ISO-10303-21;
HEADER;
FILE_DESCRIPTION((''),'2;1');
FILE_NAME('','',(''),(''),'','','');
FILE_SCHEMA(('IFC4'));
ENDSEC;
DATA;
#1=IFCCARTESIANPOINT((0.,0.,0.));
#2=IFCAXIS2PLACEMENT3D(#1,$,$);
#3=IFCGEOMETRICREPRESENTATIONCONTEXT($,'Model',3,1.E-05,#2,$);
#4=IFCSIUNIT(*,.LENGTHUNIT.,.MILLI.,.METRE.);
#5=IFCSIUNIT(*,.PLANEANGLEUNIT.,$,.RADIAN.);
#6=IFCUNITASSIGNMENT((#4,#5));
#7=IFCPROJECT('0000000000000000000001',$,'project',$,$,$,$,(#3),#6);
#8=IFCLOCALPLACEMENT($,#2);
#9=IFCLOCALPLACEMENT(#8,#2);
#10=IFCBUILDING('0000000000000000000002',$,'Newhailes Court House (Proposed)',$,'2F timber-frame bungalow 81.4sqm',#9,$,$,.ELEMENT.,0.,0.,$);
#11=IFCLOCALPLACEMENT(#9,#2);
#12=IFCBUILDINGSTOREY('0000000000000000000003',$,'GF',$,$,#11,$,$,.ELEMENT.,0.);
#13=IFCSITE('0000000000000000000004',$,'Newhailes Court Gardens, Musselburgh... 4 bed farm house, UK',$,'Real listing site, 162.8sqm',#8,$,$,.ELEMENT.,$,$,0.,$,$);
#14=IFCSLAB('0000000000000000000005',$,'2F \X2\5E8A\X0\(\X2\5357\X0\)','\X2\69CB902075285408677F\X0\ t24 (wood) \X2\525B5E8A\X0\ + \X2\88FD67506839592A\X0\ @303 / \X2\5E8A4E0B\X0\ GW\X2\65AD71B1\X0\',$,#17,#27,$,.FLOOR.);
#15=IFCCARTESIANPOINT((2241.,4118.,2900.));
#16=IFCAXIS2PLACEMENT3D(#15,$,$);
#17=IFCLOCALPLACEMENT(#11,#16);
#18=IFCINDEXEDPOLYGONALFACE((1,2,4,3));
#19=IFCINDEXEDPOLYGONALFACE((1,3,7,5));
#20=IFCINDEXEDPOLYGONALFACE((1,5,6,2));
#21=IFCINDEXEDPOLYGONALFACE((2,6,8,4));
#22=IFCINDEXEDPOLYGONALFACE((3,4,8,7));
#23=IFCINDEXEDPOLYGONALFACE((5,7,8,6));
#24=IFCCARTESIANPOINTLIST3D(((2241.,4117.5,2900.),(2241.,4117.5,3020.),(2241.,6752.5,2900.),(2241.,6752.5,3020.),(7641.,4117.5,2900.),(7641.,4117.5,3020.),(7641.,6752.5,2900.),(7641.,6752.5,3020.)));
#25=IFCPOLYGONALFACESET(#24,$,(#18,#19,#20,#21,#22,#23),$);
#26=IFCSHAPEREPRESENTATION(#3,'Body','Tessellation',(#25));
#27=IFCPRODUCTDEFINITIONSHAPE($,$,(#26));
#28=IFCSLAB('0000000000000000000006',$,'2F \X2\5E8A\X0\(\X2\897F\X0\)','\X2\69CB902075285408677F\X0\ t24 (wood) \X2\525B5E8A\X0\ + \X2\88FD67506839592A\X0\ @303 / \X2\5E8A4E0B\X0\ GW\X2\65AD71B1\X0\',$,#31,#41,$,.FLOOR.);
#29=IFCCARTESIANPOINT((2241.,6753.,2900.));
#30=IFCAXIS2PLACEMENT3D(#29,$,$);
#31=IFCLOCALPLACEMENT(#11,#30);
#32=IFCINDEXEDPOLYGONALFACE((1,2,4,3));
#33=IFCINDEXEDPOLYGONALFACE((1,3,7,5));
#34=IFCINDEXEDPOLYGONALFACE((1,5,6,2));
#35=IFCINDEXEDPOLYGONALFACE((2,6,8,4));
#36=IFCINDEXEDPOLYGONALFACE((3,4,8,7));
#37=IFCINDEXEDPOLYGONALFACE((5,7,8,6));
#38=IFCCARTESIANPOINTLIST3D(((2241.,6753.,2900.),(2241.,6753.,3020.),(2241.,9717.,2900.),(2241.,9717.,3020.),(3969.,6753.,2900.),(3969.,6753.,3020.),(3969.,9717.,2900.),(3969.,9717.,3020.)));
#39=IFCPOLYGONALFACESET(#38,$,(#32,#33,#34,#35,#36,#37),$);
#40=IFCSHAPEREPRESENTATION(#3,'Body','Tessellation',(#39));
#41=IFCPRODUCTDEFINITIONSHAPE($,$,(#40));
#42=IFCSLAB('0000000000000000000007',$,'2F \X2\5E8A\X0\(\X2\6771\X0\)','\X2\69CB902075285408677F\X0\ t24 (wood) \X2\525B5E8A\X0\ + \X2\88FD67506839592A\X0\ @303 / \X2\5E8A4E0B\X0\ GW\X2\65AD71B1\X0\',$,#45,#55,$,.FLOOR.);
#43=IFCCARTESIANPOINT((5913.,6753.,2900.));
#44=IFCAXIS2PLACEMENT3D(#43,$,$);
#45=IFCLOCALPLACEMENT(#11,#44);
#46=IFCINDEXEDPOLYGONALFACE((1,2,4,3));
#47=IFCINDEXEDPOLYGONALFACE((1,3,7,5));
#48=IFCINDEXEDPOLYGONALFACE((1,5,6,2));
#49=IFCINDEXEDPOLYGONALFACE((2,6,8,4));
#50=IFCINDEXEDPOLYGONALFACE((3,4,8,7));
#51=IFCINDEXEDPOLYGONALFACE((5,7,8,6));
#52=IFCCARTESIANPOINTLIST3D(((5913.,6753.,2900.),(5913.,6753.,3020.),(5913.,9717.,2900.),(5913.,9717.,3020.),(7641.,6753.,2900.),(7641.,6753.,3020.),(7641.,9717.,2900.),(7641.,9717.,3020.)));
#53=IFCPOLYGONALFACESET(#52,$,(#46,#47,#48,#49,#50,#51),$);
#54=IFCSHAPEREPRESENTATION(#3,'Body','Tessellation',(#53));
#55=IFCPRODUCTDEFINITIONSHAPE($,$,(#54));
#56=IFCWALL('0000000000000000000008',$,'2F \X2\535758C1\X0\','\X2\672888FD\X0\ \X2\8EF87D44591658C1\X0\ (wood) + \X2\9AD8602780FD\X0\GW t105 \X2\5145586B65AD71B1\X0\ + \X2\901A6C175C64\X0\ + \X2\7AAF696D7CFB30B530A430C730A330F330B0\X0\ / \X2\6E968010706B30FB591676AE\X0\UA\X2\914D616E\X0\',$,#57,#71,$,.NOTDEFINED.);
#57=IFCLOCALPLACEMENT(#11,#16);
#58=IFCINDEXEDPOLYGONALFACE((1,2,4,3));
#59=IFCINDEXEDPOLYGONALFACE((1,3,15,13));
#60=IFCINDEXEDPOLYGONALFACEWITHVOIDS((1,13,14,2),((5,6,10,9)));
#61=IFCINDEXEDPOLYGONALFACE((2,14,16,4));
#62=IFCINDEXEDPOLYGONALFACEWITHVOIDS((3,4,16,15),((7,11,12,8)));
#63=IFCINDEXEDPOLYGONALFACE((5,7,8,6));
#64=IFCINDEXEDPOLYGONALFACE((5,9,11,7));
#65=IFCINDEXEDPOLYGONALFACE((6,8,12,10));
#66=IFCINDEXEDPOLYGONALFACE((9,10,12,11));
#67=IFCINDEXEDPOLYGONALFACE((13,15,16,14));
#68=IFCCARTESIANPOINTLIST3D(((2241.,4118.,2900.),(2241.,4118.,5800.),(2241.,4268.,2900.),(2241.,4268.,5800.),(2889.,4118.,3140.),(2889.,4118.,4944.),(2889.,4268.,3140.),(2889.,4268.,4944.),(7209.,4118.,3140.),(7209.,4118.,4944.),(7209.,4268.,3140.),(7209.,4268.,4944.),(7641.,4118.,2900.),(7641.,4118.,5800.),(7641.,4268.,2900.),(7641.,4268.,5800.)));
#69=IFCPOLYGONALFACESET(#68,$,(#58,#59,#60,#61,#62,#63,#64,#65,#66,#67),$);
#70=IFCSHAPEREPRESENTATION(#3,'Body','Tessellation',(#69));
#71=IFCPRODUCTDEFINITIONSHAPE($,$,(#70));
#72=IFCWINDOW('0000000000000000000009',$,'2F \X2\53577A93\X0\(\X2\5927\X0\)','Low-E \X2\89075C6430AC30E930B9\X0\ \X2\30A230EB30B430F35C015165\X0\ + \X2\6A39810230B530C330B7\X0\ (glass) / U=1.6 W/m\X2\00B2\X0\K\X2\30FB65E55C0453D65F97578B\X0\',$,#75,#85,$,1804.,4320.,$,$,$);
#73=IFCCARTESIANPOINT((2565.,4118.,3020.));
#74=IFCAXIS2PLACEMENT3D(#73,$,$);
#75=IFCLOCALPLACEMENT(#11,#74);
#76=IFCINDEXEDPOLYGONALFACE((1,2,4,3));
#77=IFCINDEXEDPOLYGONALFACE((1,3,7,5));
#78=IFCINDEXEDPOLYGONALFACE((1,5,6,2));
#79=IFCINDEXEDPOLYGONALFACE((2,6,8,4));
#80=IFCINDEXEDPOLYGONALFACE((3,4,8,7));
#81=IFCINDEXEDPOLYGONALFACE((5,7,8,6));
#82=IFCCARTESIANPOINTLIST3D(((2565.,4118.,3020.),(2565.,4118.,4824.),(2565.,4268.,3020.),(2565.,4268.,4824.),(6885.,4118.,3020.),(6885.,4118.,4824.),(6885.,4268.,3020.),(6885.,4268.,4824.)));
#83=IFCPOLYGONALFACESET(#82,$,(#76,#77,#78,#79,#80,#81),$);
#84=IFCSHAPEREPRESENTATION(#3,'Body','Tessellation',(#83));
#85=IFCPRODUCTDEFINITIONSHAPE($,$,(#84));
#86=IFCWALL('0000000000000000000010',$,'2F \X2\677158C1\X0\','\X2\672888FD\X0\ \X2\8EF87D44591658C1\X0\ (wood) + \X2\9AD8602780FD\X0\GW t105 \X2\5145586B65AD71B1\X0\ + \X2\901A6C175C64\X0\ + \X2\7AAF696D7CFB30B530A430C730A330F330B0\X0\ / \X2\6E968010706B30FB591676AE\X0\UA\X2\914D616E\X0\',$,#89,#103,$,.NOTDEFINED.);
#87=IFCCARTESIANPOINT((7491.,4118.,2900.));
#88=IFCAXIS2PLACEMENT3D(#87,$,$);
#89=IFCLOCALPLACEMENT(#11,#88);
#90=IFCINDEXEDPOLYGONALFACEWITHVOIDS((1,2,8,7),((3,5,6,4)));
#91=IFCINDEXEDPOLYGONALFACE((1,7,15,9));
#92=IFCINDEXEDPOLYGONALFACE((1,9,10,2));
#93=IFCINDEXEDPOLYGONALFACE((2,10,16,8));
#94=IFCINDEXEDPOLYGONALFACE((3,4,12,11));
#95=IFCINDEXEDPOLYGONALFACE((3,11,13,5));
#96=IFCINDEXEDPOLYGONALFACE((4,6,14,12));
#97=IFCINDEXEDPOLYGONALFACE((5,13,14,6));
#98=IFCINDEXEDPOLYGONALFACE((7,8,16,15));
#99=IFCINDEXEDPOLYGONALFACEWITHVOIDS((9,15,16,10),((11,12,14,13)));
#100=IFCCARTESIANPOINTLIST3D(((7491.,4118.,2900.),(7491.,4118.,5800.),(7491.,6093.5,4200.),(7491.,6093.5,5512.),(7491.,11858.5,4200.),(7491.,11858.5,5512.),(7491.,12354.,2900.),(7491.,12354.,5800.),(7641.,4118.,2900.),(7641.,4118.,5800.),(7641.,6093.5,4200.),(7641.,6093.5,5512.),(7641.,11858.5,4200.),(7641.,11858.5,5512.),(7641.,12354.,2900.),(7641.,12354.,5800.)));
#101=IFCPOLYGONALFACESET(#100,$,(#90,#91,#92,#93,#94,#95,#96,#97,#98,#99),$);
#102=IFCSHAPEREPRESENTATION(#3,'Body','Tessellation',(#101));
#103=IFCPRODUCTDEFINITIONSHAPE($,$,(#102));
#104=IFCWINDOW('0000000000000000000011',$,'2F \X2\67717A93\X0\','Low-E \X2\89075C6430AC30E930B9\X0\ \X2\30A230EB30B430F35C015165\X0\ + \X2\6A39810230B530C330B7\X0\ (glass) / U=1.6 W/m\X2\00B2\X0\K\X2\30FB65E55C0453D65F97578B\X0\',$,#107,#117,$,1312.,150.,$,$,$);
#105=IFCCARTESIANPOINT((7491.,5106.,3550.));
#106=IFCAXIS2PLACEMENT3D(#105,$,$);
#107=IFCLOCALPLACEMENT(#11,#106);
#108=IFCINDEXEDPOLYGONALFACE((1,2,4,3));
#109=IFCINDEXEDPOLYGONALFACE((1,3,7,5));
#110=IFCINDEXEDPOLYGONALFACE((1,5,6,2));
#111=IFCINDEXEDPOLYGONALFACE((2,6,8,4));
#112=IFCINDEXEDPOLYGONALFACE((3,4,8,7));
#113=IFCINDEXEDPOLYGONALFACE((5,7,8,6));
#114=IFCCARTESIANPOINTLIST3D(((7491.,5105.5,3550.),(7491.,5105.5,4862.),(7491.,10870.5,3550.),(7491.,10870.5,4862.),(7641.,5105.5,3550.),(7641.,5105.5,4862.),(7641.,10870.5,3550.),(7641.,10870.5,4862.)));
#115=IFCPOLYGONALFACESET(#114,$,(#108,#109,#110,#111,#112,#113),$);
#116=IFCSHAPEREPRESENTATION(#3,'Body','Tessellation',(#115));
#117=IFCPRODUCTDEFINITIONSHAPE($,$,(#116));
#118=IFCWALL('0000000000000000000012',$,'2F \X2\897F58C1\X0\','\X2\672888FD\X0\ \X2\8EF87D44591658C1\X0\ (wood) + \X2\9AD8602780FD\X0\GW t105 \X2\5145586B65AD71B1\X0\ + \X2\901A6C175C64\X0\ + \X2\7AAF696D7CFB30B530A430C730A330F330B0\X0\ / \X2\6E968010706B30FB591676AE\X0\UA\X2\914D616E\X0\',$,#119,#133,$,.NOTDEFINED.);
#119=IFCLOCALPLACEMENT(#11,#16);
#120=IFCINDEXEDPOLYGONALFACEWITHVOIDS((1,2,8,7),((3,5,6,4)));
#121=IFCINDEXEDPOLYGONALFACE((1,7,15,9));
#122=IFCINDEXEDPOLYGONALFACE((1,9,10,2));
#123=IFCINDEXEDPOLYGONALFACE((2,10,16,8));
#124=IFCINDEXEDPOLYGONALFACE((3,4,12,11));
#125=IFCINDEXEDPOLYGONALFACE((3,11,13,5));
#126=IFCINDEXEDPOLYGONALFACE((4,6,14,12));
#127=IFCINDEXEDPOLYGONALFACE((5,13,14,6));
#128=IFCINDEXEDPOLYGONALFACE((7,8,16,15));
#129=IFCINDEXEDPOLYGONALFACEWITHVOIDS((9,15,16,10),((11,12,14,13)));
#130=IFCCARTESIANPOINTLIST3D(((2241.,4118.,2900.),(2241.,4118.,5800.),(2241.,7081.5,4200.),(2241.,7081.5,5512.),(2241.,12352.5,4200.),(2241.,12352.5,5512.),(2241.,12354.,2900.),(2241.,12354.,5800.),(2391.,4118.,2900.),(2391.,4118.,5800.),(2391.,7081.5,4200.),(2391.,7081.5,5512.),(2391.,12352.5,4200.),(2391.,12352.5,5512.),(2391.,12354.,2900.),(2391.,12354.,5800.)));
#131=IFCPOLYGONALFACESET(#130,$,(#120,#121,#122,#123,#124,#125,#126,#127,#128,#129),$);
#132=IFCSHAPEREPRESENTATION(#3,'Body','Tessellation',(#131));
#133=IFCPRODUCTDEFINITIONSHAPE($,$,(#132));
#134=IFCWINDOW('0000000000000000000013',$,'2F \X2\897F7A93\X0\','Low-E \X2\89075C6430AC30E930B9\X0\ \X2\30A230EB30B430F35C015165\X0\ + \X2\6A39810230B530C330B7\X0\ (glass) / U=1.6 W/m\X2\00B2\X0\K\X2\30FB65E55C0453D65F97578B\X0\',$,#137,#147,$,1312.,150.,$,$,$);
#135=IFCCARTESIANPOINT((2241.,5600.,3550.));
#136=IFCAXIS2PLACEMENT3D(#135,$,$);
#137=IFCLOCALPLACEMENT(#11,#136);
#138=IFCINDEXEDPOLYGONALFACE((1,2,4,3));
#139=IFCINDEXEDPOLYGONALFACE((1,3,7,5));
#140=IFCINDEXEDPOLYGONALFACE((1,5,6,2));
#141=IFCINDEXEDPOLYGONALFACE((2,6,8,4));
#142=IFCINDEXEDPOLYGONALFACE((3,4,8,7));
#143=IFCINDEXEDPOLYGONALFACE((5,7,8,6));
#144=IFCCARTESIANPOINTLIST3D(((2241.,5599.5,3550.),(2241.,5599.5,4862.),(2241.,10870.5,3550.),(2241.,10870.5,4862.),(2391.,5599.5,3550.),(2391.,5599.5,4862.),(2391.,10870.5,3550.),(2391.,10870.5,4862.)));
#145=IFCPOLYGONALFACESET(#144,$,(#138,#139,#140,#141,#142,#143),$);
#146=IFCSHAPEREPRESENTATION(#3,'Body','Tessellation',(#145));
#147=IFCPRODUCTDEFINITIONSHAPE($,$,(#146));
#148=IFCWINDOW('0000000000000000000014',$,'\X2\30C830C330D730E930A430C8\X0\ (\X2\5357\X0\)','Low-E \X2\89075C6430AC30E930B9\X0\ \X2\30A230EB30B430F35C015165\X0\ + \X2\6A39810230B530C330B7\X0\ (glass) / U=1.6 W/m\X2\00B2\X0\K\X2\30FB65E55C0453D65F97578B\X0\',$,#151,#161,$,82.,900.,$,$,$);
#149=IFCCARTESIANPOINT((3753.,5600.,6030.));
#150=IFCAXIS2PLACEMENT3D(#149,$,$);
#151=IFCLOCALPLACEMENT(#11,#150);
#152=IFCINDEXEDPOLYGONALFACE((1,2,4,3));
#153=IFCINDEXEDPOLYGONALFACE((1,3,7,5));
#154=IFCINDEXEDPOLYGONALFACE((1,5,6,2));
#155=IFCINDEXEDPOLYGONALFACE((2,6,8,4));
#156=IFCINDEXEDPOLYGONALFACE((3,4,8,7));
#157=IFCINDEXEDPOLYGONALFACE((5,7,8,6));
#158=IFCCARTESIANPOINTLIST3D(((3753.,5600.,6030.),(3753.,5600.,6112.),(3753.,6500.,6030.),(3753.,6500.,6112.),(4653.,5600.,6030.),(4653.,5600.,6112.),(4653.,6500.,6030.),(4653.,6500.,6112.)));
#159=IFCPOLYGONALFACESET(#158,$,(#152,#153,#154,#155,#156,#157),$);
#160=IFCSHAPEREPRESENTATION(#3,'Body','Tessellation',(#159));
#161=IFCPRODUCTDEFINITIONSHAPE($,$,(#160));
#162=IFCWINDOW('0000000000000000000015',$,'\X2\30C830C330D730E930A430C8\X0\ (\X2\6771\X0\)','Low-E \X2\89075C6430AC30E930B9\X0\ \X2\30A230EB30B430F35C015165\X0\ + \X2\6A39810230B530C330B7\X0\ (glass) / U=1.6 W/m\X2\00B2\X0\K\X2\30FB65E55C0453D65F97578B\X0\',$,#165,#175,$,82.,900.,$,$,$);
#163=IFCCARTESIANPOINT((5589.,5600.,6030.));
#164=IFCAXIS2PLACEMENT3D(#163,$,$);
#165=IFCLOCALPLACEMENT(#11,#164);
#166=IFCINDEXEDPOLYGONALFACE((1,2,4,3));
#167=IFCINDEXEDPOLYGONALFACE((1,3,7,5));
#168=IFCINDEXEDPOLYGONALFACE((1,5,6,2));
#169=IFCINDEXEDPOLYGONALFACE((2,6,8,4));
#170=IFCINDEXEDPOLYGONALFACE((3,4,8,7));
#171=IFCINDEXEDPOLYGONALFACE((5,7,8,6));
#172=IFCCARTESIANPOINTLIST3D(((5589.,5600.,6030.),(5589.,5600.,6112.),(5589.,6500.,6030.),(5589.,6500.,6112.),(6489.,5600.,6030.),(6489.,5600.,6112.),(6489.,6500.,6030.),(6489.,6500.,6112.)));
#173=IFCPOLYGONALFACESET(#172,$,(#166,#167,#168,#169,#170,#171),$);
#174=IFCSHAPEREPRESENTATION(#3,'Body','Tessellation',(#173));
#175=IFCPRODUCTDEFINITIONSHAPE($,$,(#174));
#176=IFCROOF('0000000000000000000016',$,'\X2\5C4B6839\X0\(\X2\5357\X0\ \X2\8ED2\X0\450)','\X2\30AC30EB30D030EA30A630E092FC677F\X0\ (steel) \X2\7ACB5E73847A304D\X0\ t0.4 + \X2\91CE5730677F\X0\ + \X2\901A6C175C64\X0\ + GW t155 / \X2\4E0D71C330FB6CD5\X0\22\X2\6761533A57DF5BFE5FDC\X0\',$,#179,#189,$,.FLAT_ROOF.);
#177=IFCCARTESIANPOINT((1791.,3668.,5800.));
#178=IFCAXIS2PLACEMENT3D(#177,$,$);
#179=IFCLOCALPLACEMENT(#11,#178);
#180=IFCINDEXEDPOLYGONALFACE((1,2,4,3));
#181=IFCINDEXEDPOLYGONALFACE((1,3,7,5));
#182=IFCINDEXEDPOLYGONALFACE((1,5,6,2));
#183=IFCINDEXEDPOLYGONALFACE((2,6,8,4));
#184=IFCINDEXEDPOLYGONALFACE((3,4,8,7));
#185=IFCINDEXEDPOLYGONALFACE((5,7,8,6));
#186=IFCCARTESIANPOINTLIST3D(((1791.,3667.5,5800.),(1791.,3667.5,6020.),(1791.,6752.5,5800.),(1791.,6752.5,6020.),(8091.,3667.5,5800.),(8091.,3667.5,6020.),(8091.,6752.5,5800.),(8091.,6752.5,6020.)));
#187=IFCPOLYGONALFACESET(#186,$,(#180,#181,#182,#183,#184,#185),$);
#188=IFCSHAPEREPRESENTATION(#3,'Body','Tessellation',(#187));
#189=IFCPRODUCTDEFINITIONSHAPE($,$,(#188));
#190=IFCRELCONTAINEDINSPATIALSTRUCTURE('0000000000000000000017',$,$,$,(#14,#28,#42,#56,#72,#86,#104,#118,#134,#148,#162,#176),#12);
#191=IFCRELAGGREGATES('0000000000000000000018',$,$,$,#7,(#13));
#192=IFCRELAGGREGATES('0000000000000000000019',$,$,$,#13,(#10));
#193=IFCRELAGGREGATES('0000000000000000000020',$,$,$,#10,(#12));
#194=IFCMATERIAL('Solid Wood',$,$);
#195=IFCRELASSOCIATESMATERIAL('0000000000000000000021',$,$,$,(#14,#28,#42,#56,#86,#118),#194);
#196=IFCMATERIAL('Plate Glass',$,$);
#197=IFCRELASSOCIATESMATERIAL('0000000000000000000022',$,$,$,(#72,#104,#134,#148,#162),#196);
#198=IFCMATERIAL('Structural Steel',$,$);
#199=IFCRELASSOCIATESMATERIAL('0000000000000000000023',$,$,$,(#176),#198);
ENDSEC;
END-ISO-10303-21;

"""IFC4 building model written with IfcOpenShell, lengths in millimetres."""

from ifc_helpers import new_model, si_unit, frame, frame_2d, origin, place, context, project, spatial, rectangle, extrude, material, element, fill, save


model = new_model("IFC4")

# Units and contexts
model_context = context("Model", 3, precision=1e-05, world=origin())
ifc_project = project(units=[si_unit("LENGTHUNIT", "METRE", prefix="MILLI"), si_unit("PLANEANGLEUNIT", "RADIAN")], contexts=[model_context])

# Site, building, storey
site_placement = place(None, origin())
site = spatial("IfcSite", under=ifc_project, at=site_placement, Name="Newhailes Court Gardens, Musselburgh... 4 bed farm house, UK", ObjectType="Real listing site, 162.8sqm", CompositionType="ELEMENT", RefElevation=0.0)
building_placement = place(site_placement, origin())
building = spatial("IfcBuilding", under=site, at=building_placement, Name="Newhailes Court House (Proposed)", ObjectType="2F timber-frame bungalow 81.4sqm", CompositionType="ELEMENT", ElevationOfRefHeight=0.0, ElevationOfTerrain=0.0)
storey_placement = place(building_placement, origin())
storey = spatial("IfcBuildingStorey", under=building, at=storey_placement, Name="GF", CompositionType="ELEMENT", Elevation=0.0)

# Slabs
ifc_material_1 = material(Name="Solid Wood")
slab_1_placement = place(storey_placement, frame((2241.0, 4118.0, 2900.0)))
element("IfcSlab", 1, at=slab_1_placement, inside=storey, material=ifc_material_1, Name="2F 床(南)", Description="構造用合板 t24 (wood) 剛床 + 製材根太 @303 / 床下 GW断熱", PredefinedType="FLOOR", context=model_context, shape_type="SweptSolid", body=[
    extrude(rectangle(XDim=5400.0, YDim=2635.0, at=frame_2d((2700.0, 1317.0))), frame((2241.0, 4118.0, 2900.0)), (0.0, 0.0, 1.0), 120.0),
])
slab_2_placement = place(storey_placement, frame((2241.0, 6753.0, 2900.0)))
element("IfcSlab", 2, at=slab_2_placement, inside=storey, material=ifc_material_1, Name="2F 床(西)", Description="構造用合板 t24 (wood) 剛床 + 製材根太 @303 / 床下 GW断熱", PredefinedType="FLOOR", context=model_context, shape_type="SweptSolid", body=[
    extrude(rectangle(XDim=1728.0, YDim=2964.0, at=frame_2d((864.0, 1482.0))), frame((2241.0, 6753.0, 2900.0)), (0.0, 0.0, 1.0), 120.0),
])
slab_3_placement = place(storey_placement, frame((5913.0, 6753.0, 2900.0)))
element("IfcSlab", 3, at=slab_3_placement, inside=storey, material=ifc_material_1, Name="2F 床(東)", Description="構造用合板 t24 (wood) 剛床 + 製材根太 @303 / 床下 GW断熱", PredefinedType="FLOOR", context=model_context, shape_type="SweptSolid", body=[
    extrude(rectangle(XDim=1728.0, YDim=2964.0, at=frame_2d((864.0, 1482.0))), frame((5913.0, 6753.0, 2900.0)), (0.0, 0.0, 1.0), 120.0),
])

# Walls, openings, windows
wall_1_placement = place(storey_placement, frame((2241.0, 4118.0, 2900.0)))
wall_1 = element("IfcWall", 4, at=wall_1_placement, inside=storey, material=ifc_material_1, Name="2F 南壁", Description="木製 軸組外壁 (wood) + 高性能GW t105 充填断熱 + 通気層 + 窯業系サイディング / 準耐火・外皮UA配慮", PredefinedType="NOTDEFINED", context=model_context, shape_type="SweptSolid", body=[
    extrude(rectangle(XDim=5400.0, YDim=150.0, at=frame_2d((2700.0, 75.0))), frame((2241.0, 4118.0, 2900.0)), (0.0, 0.0, 1.0), 2900.0),
])
opening_1_placement = place(storey_placement, frame((2565.0, 4118.0, 3020.0)))
opening_1 = element("IfcOpeningElement", 5, at=opening_1_placement, cuts=wall_1, PredefinedType="NOTDEFINED", context=model_context, shape_type="SweptSolid", body=[
    extrude(rectangle(XDim=4320.0, YDim=150.0, at=frame_2d((2160.0, 75.0))), frame((2565.0, 4118.0, 3020.0)), (0.0, 0.0, 1.0), 1804.0),
])
ifc_material_2 = material(Name="Plate Glass")
window_1_placement = place(storey_placement, frame((2565.0, 4118.0, 3020.0)))
window_1 = element("IfcWindow", 6, at=window_1_placement, inside=storey, material=ifc_material_2, Name="2F 南窓(大)", Description="Low-E 複層ガラス アルゴン封入 + 樹脂サッシ (glass) / U=1.6 W/m²K・日射取得型", OverallHeight=1804.0, OverallWidth=4320.0, context=model_context, shape_type="SweptSolid", body=[
    extrude(rectangle(XDim=4320.0, YDim=150.0, at=frame_2d((2160.0, 75.0))), frame((2565.0, 4118.0, 3020.0)), (0.0, 0.0, 1.0), 1804.0),
])
fill(opening_1, window_1)
wall_2_placement = place(storey_placement, frame((7491.0, 4118.0, 2900.0)))
wall_2 = element("IfcWall", 7, at=wall_2_placement, inside=storey, material=ifc_material_1, Name="2F 東壁", Description="木製 軸組外壁 (wood) + 高性能GW t105 充填断熱 + 通気層 + 窯業系サイディング / 準耐火・外皮UA配慮", PredefinedType="NOTDEFINED", context=model_context, shape_type="SweptSolid", body=[
    extrude(rectangle(XDim=150.0, YDim=8236.0, at=frame_2d((75.0, 4118.0))), frame((7491.0, 4118.0, 2900.0)), (0.0, 0.0, 1.0), 2900.0),
])
opening_2_placement = place(storey_placement, frame((7491.0, 5106.0, 3550.0)))
opening_2 = element("IfcOpeningElement", 8, at=opening_2_placement, cuts=wall_2, PredefinedType="NOTDEFINED", context=model_context, shape_type="SweptSolid", body=[
    extrude(rectangle(XDim=150.0, YDim=5765.0, at=frame_2d((75.0, 2882.0))), frame((7491.0, 5106.0, 3550.0)), (0.0, 0.0, 1.0), 1312.0),
])
window_2_placement = place(storey_placement, frame((7491.0, 5106.0, 3550.0)))
window_2 = element("IfcWindow", 9, at=window_2_placement, inside=storey, material=ifc_material_2, Name="2F 東窓", Description="Low-E 複層ガラス アルゴン封入 + 樹脂サッシ (glass) / U=1.6 W/m²K・日射取得型", OverallHeight=1312.0, OverallWidth=150.0, context=model_context, shape_type="SweptSolid", body=[
    extrude(rectangle(XDim=150.0, YDim=5765.0, at=frame_2d((75.0, 2882.0))), frame((7491.0, 5106.0, 3550.0)), (0.0, 0.0, 1.0), 1312.0),
])
fill(opening_2, window_2)
wall_3_placement = place(storey_placement, frame((2241.0, 4118.0, 2900.0)))
wall_3 = element("IfcWall", 10, at=wall_3_placement, inside=storey, material=ifc_material_1, Name="2F 西壁", Description="木製 軸組外壁 (wood) + 高性能GW t105 充填断熱 + 通気層 + 窯業系サイディング / 準耐火・外皮UA配慮", PredefinedType="NOTDEFINED", context=model_context, shape_type="SweptSolid", body=[
    extrude(rectangle(XDim=150.0, YDim=8236.0, at=frame_2d((75.0, 4118.0))), frame((2241.0, 4118.0, 2900.0)), (0.0, 0.0, 1.0), 2900.0),
])
opening_3_placement = place(storey_placement, frame((2241.0, 5600.0, 3550.0)))
opening_3 = element("IfcOpeningElement", 11, at=opening_3_placement, cuts=wall_3, PredefinedType="NOTDEFINED", context=model_context, shape_type="SweptSolid", body=[
    extrude(rectangle(XDim=150.0, YDim=5271.0, at=frame_2d((75.0, 2635.0))), frame((2241.0, 5600.0, 3550.0)), (0.0, 0.0, 1.0), 1312.0),
])
window_3_placement = place(storey_placement, frame((2241.0, 5600.0, 3550.0)))
window_3 = element("IfcWindow", 12, at=window_3_placement, inside=storey, material=ifc_material_2, Name="2F 西窓", Description="Low-E 複層ガラス アルゴン封入 + 樹脂サッシ (glass) / U=1.6 W/m²K・日射取得型", OverallHeight=1312.0, OverallWidth=150.0, context=model_context, shape_type="SweptSolid", body=[
    extrude(rectangle(XDim=150.0, YDim=5271.0, at=frame_2d((75.0, 2635.0))), frame((2241.0, 5600.0, 3550.0)), (0.0, 0.0, 1.0), 1312.0),
])
fill(opening_3, window_3)

# Windows
window_4_placement = place(storey_placement, frame((3753.0, 5600.0, 6030.0)))
element("IfcWindow", 13, at=window_4_placement, inside=storey, material=ifc_material_2, Name="トップライト (南)", Description="Low-E 複層ガラス アルゴン封入 + 樹脂サッシ (glass) / U=1.6 W/m²K・日射取得型", OverallHeight=82.0, OverallWidth=900.0, context=model_context, shape_type="SweptSolid", body=[
    extrude(rectangle(XDim=900.0, YDim=900.0, at=frame_2d((450.0, 450.0))), frame((3753.0, 5600.0, 6030.0)), (0.0, 0.0, 1.0), 82.0),
])
window_5_placement = place(storey_placement, frame((5589.0, 5600.0, 6030.0)))
element("IfcWindow", 14, at=window_5_placement, inside=storey, material=ifc_material_2, Name="トップライト (東)", Description="Low-E 複層ガラス アルゴン封入 + 樹脂サッシ (glass) / U=1.6 W/m²K・日射取得型", OverallHeight=82.0, OverallWidth=900.0, context=model_context, shape_type="SweptSolid", body=[
    extrude(rectangle(XDim=900.0, YDim=900.0, at=frame_2d((450.0, 450.0))), frame((5589.0, 5600.0, 6030.0)), (0.0, 0.0, 1.0), 82.0),
])

# Roof
ifc_material_3 = material(Name="Structural Steel")
roof_1_placement = place(storey_placement, frame((1791.0, 3668.0, 5800.0)))
element("IfcRoof", 15, at=roof_1_placement, inside=storey, material=ifc_material_3, Name="屋根(南 軒450)", Description="ガルバリウム鋼板 (steel) 立平葺き t0.4 + 野地板 + 通気層 + GW t155 / 不燃・法22条区域対応", PredefinedType="FLAT_ROOF", context=model_context, shape_type="SweptSolid", body=[
    extrude(rectangle(XDim=6300.0, YDim=3085.0, at=frame_2d((3150.0, 1542.0))), frame((1791.0, 3668.0, 5800.0)), (0.0, 0.0, 1.0), 220.0),
])

save(model, "model.ifc")
